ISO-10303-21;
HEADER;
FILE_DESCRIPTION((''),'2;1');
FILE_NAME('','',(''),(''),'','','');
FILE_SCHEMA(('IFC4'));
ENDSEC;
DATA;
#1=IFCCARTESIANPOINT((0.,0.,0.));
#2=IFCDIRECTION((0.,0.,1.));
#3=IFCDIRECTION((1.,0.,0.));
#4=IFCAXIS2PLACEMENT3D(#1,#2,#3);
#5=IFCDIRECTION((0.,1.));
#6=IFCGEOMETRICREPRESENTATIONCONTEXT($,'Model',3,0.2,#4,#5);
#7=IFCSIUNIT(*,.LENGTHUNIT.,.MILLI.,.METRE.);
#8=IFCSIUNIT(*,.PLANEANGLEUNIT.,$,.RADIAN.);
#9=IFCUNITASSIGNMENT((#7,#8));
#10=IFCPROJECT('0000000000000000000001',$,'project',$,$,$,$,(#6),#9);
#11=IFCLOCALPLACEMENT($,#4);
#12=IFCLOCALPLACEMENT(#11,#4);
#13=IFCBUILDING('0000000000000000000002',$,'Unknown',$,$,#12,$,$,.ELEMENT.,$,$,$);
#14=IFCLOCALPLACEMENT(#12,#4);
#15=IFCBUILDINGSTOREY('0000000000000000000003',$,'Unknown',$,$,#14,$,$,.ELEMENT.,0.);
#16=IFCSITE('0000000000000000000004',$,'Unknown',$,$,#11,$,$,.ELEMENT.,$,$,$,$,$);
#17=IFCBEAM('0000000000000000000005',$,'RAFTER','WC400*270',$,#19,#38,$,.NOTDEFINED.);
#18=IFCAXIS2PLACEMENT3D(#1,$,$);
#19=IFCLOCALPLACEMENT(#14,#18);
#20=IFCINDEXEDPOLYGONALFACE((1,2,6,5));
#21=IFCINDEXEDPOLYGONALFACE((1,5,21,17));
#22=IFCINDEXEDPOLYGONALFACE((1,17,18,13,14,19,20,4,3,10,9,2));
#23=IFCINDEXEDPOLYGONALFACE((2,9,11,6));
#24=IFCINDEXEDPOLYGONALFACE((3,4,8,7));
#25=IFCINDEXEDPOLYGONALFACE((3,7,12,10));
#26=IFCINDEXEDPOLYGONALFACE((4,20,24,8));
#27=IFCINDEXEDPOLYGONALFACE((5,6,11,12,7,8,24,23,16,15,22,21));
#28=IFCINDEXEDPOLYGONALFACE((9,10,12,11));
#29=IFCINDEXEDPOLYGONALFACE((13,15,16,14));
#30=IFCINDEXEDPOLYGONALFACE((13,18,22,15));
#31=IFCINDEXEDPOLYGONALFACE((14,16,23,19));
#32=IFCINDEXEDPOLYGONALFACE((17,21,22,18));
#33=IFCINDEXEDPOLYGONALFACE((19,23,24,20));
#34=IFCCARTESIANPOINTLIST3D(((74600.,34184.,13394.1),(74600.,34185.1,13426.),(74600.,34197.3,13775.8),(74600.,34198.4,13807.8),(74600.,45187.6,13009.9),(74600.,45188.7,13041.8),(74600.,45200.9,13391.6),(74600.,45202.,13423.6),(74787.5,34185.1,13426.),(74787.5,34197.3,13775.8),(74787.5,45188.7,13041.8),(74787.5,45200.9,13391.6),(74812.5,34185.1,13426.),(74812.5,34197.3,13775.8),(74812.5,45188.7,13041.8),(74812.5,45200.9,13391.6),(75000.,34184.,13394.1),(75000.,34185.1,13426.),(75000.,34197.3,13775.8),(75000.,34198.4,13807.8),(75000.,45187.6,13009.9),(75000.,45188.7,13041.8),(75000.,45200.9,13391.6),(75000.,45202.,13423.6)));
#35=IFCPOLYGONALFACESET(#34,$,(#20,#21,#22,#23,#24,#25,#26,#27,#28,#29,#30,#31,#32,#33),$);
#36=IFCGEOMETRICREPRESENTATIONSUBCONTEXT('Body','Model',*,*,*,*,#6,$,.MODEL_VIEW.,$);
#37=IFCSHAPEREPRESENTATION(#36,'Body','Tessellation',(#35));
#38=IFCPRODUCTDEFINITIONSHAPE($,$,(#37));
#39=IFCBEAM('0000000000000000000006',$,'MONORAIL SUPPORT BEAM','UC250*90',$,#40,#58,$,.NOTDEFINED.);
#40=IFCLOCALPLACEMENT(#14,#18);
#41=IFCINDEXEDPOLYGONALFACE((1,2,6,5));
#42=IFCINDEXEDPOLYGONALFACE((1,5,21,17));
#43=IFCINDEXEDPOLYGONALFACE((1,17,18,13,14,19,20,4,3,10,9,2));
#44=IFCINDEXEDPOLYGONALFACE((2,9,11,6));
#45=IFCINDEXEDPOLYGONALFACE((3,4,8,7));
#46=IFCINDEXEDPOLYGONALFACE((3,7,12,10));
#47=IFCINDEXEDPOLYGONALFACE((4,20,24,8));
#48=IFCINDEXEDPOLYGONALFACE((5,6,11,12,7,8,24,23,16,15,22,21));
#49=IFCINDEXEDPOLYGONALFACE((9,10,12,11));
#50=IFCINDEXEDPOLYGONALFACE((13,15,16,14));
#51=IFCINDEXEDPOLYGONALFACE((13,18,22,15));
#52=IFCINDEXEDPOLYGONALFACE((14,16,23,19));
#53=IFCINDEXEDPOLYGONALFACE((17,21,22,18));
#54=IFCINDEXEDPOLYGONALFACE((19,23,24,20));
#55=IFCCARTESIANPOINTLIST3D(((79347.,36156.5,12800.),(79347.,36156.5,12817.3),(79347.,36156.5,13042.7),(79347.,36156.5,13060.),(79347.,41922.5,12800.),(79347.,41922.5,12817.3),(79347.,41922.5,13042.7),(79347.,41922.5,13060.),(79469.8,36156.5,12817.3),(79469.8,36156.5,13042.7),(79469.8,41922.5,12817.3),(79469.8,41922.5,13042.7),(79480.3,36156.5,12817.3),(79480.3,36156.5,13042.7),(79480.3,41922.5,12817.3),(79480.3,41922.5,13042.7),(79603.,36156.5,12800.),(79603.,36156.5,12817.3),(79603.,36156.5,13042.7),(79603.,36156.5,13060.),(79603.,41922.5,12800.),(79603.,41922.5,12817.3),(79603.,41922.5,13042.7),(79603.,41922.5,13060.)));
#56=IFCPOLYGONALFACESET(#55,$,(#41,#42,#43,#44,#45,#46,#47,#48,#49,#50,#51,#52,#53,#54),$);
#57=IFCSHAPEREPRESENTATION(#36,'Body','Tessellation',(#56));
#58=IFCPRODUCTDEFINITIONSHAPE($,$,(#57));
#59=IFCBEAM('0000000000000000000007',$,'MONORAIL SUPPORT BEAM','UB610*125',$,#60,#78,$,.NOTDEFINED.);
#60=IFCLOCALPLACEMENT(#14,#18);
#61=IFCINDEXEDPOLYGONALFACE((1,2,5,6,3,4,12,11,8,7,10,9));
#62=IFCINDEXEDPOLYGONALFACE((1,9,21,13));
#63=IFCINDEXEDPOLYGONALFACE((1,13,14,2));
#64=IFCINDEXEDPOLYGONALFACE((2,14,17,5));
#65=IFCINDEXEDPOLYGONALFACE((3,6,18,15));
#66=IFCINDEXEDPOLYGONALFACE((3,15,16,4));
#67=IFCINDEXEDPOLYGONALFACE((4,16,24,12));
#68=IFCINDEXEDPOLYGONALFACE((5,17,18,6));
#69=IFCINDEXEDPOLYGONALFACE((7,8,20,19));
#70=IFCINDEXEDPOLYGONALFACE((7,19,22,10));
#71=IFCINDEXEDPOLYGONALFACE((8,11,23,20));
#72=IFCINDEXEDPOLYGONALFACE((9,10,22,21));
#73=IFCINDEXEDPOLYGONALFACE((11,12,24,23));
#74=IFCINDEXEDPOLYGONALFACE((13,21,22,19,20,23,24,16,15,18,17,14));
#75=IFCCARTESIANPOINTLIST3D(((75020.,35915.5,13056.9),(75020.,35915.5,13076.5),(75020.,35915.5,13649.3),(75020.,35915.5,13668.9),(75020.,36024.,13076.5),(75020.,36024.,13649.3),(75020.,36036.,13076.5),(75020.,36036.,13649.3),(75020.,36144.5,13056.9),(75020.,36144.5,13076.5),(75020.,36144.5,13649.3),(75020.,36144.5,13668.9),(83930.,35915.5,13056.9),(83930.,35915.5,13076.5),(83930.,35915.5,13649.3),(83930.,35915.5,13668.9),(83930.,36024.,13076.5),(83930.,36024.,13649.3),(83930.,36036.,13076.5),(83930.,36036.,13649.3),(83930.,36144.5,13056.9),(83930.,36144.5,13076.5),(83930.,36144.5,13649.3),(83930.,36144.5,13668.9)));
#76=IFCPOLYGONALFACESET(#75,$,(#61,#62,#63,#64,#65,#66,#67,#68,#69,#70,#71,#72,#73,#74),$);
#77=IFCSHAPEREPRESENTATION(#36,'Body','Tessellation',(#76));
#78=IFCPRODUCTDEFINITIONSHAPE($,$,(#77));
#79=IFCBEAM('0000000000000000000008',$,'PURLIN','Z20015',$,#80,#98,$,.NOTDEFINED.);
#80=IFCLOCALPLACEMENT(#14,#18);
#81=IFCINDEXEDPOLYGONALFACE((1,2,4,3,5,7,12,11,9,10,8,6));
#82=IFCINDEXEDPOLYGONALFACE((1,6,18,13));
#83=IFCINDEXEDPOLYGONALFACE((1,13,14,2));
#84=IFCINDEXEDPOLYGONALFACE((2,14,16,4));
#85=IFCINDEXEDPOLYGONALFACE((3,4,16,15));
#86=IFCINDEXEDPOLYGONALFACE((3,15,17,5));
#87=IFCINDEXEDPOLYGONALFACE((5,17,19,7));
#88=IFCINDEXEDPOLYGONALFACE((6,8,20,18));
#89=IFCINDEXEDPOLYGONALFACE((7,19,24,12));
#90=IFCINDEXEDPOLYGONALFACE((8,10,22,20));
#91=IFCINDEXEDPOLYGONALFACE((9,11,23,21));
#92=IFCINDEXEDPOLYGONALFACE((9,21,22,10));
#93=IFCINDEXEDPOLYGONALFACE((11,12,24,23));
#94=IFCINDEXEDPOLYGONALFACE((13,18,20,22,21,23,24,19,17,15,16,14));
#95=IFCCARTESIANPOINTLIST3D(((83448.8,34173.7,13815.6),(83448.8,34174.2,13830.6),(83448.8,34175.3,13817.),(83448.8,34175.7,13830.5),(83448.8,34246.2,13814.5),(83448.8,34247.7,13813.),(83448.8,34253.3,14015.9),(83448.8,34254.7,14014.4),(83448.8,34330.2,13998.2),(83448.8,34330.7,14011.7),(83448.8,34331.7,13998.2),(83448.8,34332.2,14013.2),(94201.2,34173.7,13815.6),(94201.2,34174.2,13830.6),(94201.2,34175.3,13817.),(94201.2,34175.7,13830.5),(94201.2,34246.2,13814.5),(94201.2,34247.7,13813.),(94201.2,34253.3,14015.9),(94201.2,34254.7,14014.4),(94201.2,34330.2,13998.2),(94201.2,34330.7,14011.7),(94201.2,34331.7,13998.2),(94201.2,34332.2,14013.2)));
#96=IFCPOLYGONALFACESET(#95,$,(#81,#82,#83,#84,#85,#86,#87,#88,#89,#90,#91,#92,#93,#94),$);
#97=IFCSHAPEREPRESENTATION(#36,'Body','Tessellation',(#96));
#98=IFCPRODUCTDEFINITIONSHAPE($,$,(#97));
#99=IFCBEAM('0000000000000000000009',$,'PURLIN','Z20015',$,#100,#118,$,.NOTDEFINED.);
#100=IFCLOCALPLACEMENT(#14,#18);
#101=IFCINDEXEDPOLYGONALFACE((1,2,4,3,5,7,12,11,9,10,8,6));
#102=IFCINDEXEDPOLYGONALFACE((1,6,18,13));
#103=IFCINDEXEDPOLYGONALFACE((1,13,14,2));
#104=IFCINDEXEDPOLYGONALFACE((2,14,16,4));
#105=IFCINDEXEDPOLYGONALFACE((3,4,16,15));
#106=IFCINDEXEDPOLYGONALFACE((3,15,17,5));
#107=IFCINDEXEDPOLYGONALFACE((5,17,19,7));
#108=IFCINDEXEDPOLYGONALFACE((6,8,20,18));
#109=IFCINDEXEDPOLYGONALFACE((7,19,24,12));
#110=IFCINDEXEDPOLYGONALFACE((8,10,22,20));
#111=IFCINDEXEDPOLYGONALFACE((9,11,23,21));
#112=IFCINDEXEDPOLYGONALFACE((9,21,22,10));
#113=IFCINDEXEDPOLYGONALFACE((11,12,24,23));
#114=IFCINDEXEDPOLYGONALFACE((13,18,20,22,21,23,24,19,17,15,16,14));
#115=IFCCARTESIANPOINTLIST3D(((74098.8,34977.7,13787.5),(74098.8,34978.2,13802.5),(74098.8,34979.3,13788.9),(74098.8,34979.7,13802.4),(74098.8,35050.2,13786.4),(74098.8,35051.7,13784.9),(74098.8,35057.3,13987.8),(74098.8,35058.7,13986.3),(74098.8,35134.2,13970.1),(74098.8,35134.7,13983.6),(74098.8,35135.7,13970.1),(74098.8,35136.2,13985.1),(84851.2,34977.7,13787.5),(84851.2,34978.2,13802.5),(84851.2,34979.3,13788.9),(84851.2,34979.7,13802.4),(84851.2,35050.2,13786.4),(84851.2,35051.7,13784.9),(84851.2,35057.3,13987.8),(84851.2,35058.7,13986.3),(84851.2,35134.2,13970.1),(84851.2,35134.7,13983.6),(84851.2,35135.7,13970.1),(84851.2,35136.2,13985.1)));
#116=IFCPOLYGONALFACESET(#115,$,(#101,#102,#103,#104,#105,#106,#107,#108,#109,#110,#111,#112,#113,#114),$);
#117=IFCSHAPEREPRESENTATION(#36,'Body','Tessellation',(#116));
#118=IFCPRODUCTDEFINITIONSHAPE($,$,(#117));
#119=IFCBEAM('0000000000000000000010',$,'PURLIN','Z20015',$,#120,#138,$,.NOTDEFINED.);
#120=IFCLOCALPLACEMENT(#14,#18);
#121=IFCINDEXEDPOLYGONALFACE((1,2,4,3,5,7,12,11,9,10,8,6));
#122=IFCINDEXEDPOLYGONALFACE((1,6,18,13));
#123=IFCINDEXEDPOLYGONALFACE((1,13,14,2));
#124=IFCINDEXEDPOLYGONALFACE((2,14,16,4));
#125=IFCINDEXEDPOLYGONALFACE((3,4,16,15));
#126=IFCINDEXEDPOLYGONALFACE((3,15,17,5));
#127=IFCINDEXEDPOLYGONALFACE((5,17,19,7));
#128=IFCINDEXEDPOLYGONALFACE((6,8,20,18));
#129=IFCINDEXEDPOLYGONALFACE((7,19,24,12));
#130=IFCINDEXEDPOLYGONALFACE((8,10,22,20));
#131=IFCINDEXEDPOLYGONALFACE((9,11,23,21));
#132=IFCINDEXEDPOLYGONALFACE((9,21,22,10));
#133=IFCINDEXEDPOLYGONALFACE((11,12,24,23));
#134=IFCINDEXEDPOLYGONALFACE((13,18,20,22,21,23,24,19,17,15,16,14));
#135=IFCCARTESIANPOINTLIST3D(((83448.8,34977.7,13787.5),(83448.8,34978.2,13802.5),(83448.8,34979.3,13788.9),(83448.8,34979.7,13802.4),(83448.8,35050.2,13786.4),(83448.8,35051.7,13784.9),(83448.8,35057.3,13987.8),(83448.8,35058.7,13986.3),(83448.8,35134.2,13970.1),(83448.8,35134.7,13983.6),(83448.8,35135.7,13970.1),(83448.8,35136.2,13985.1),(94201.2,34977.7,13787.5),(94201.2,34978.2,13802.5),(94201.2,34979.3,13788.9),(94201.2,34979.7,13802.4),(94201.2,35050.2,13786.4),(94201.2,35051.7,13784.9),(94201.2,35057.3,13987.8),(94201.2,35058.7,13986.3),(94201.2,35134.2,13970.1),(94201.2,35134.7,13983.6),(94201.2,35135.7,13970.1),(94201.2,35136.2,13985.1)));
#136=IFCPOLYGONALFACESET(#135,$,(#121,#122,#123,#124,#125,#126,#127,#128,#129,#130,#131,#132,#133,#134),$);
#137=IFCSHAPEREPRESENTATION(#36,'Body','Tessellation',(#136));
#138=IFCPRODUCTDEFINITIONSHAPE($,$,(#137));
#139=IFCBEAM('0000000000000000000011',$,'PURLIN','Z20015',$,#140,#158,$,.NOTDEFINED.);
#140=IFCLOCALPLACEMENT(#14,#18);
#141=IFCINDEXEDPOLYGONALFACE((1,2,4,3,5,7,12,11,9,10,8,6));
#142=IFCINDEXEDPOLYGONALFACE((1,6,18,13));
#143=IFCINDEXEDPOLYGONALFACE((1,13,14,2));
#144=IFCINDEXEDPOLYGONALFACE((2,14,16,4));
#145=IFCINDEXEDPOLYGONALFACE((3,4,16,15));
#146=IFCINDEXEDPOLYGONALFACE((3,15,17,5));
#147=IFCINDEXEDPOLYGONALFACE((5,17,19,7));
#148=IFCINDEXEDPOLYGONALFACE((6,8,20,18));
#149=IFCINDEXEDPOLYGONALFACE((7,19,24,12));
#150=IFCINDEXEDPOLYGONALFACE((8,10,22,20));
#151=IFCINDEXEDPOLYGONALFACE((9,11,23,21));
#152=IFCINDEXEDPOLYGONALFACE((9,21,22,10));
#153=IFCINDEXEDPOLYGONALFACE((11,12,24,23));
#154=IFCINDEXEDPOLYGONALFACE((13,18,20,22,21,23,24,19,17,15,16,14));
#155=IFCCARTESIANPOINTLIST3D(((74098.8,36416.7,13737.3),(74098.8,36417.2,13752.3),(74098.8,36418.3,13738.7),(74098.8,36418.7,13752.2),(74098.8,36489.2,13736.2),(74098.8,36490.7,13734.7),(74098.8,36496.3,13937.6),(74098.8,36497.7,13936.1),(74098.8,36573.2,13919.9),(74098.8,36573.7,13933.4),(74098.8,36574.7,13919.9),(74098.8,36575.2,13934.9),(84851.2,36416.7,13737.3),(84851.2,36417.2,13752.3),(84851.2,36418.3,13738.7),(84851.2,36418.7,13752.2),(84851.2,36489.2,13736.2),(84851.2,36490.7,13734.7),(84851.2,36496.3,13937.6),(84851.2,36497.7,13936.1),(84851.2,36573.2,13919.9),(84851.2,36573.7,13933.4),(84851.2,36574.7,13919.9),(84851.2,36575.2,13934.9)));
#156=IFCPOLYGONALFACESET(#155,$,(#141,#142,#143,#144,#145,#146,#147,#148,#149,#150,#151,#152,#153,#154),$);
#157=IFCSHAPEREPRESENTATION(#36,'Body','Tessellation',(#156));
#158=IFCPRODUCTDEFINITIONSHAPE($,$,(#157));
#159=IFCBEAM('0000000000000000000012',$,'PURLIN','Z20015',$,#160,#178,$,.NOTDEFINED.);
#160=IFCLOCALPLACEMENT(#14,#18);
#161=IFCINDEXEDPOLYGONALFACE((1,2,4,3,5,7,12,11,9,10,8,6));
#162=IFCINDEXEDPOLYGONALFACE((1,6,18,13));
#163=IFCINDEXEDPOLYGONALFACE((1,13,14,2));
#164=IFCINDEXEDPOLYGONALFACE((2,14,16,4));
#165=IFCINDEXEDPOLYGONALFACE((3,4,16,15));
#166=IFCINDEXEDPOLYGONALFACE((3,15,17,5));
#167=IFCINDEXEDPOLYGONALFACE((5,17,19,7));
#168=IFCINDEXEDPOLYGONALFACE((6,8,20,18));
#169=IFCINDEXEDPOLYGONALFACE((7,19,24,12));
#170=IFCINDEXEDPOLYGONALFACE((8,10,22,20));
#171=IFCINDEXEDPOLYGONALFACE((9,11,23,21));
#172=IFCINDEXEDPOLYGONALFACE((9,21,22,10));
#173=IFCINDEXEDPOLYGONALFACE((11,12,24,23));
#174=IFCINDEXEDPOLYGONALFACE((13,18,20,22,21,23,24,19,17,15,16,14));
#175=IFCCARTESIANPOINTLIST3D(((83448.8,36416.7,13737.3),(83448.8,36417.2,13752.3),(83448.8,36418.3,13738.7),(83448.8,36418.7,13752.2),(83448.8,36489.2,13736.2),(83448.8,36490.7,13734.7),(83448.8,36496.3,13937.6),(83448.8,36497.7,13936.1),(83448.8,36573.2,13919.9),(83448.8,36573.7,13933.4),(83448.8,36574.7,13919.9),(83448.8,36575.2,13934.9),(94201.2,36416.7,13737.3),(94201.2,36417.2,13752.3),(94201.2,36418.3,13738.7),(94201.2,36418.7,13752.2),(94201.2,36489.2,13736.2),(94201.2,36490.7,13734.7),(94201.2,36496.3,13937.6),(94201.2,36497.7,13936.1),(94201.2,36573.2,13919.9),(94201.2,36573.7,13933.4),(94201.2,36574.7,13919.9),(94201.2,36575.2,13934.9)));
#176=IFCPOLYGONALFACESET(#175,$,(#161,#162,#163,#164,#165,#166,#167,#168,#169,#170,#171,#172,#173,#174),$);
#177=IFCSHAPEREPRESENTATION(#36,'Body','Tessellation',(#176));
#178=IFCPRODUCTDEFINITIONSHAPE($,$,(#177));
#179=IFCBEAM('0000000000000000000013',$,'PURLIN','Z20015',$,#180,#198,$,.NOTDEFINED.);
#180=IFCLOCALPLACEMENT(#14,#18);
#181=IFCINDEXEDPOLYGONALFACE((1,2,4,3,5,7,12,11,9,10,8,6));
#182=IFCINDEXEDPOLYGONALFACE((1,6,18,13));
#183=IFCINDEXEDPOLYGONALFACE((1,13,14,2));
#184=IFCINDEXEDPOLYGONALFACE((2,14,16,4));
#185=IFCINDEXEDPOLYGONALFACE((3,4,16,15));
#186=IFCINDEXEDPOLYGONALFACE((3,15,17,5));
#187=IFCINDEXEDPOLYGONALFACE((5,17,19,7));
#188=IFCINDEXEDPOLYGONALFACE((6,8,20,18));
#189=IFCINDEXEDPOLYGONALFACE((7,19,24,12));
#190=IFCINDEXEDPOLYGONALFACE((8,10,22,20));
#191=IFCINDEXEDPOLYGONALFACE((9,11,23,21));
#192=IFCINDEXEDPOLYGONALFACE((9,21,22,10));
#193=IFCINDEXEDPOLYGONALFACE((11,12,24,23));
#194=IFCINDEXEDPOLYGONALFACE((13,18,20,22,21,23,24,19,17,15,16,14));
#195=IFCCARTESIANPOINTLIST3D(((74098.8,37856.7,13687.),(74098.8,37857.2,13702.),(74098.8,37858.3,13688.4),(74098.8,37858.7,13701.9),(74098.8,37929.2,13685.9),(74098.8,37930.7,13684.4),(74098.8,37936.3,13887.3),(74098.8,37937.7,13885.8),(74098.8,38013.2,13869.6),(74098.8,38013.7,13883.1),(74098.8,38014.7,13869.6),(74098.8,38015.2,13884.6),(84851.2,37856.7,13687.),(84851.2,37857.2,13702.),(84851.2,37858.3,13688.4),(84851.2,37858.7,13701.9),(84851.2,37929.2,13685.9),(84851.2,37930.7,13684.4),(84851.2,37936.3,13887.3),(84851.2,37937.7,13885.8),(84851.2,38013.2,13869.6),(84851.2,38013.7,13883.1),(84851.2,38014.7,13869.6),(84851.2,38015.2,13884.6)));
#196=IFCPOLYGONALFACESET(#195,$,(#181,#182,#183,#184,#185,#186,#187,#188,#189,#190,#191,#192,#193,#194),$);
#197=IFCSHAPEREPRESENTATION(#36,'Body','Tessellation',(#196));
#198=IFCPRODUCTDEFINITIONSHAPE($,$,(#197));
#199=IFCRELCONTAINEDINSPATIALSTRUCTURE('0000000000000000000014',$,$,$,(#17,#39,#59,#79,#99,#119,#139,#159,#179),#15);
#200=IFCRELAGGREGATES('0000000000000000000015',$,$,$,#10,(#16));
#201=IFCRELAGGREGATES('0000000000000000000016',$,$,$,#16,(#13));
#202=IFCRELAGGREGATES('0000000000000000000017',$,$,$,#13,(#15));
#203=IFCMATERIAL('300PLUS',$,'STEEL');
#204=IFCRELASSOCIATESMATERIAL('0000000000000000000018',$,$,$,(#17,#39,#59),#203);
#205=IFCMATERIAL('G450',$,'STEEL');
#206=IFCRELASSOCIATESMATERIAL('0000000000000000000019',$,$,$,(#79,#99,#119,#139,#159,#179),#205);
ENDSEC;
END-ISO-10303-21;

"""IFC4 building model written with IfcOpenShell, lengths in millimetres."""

from ifc_helpers import new_model, si_unit, direction, frame, origin_with_axes, place, context, subcontext, project, spatial, line, indexed_curve, outline, extrude, material, element, save


model = new_model("IFC4")

# Units and contexts
model_context = context("Model", 3, precision=0.2, world=origin_with_axes(), true_north=direction((0.0, 1.0)))
body_context = subcontext(model_context, "Body", "Model", "MODEL_VIEW")
ifc_project = project(units=[si_unit("LENGTHUNIT", "METRE", prefix="MILLI"), si_unit("PLANEANGLEUNIT", "RADIAN")], contexts=[model_context])

# Site, building, storey
site_placement = place(None, origin_with_axes())
site = spatial("IfcSite", under=ifc_project, at=site_placement, Name="Unknown", CompositionType="ELEMENT")
building_placement = place(site_placement, origin_with_axes())
building = spatial("IfcBuilding", under=site, at=building_placement, Name="Unknown", CompositionType="ELEMENT")
storey_placement = place(building_placement, origin_with_axes())
storey = spatial("IfcBuildingStorey", under=building, at=storey_placement, Name="Unknown", CompositionType="ELEMENT", Elevation=0.0)

# Beams
ifc_material_1 = material(Name="300PLUS", Category="STEEL")
beam_1_placement = place(storey_placement, frame((74800.0, 34191.2, 13600.9), z_axis=(1.0, 0.0, 0.0), x_axis=(0.0, 0.999391, -0.034895)))
element("IfcBeam", 1, at=beam_1_placement, inside=storey, material=ifc_material_1, Name="RAFTER", Description="WC400*270", PredefinedType="NOTDEFINED", context=body_context, shape_type="SolidModel", body=[
    extrude(outline(indexed_curve([(-200.0, -207.0), (200.0, -207.0), (200.0, -175.0), (12.5, -175.0), (12.5, 175.0), (200.0, 175.0), (200.0, 207.0), (-200.0, 207.0), (-200.0, 175.0), (-12.5, 175.0), (-12.5, -175.0), (-200.0, -175.0)], segments=[line(1, 2, 3, 4, 5, 6, 7, 8, 9, 10, 11, 12, 1)])), frame((0.0, 0.0, 0.0), z_axis=(-1.0, 0.0, 0.0), x_axis=(0.0, 0.0, 1.0)), (0.0, 0.0, -1.0), 11010.3),
])
beam_2_placement = place(storey_placement, frame((79475.0, 36156.5, 12930.0), z_axis=(1.0, 0.0, 0.0), x_axis=(0.0, 1.0, 0.0)))
element("IfcBeam", 2, at=beam_2_placement, inside=storey, material=ifc_material_1, Name="MONORAIL SUPPORT BEAM", Description="UC250*90", PredefinedType="NOTDEFINED", context=body_context, shape_type="SolidModel", body=[
    extrude(outline(indexed_curve([(-128.0, -130.0), (128.0, -130.0), (128.0, -112.7), (5.2, -112.7), (5.2, 112.7), (128.0, 112.7), (128.0, 130.0), (-128.0, 130.0), (-128.0, 112.7), (-5.2, 112.7), (-5.2, -112.7), (-128.0, -112.7)], segments=[line(1, 2, 3, 4, 5, 6, 7, 8, 9, 10, 11, 12, 1)])), frame((0.0, 0.0, 0.0), z_axis=(-1.0, 0.0, 0.0), x_axis=(0.0, 0.0, 1.0)), (0.0, 0.0, -1.0), 5766.0),
])
beam_3_placement = place(storey_placement, frame((75020.0, 36030.0, 13362.9), z_axis=(0.0, -1.0, 0.0), x_axis=(1.0, 0.0, 0.0)))
element("IfcBeam", 3, at=beam_3_placement, inside=storey, material=ifc_material_1, Name="MONORAIL SUPPORT BEAM", Description="UB610*125", PredefinedType="NOTDEFINED", context=body_context, shape_type="SolidModel", body=[
    extrude(outline(indexed_curve([(-114.5, -306.0), (114.5, -306.0), (114.5, -286.4), (6.0, -286.4), (6.0, 286.4), (114.5, 286.4), (114.5, 306.0), (-114.5, 306.0), (-114.5, 286.4), (-6.0, 286.4), (-6.0, -286.4), (-114.5, -286.4)], segments=[line(1, 2, 3, 4, 5, 6, 7, 8, 9, 10, 11, 12, 1)])), frame((0.0, 0.0, 0.0), z_axis=(-1.0, 0.0, 0.0), x_axis=(0.0, 0.0, 1.0)), (0.0, 0.0, -1.0), 8910.0),
])
ifc_material_2 = material(Name="G450", Category="STEEL")
for number, where, z_axis, x_axis, name in (
    (4, (83448.8, 34250.5, 13914.5), (0.0, -0.999391, 0.034899), (1.0, 0.0, 0.0), "PURLIN"),
    (5, (74098.8, 35054.5, 13886.4), (0.0, -0.999391, 0.034899), (1.0, 0.0, 0.0), "PURLIN"),
    (6, (83448.8, 35054.5, 13886.4), (0.0, -0.999391, 0.034899), (1.0, 0.0, 0.0), "PURLIN"),
    (7, (74098.8, 36493.5, 13836.2), (0.0, -0.999391, 0.034899), (1.0, 0.0, 0.0), "PURLIN"),
    (8, (83448.8, 36493.5, 13836.2), (0.0, -0.999391, 0.034899), (1.0, 0.0, 0.0), "PURLIN"),
    (9, (74098.8, 37933.5, 13785.9), (0.0, -0.999391, 0.034899), (1.0, 0.0, 0.0), "PURLIN"),
):
    element("IfcBeam", number, at=place(storey_placement, frame(where, z_axis=z_axis, x_axis=x_axis)), inside=storey, material=ifc_material_2, Name=name, Description="Z20015", PredefinedType="NOTDEFINED", context=body_context, shape_type="SolidModel", body=[
        extrude(outline(indexed_curve([(73.2, -101.5), (73.2, -86.5), (71.8, -86.5), (71.8, -100.0), (0.8, -100.0), (0.8, 101.5), (-78.2, 101.5), (-78.2, 86.5), (-76.8, 86.5), (-76.8, 100.0), (-0.8, 100.0), (-0.8, -101.5)], segments=[line(1, 2, 3, 4, 5, 6, 7, 8, 9, 10, 11, 12, 1)])), frame((0.0, 0.0, 0.0), z_axis=(-1.0, 0.0, 0.0), x_axis=(0.0, 0.0, 1.0)), (0.0, 0.0, -1.0), 10752.4),
    ])

save(model, "model.ifc")
